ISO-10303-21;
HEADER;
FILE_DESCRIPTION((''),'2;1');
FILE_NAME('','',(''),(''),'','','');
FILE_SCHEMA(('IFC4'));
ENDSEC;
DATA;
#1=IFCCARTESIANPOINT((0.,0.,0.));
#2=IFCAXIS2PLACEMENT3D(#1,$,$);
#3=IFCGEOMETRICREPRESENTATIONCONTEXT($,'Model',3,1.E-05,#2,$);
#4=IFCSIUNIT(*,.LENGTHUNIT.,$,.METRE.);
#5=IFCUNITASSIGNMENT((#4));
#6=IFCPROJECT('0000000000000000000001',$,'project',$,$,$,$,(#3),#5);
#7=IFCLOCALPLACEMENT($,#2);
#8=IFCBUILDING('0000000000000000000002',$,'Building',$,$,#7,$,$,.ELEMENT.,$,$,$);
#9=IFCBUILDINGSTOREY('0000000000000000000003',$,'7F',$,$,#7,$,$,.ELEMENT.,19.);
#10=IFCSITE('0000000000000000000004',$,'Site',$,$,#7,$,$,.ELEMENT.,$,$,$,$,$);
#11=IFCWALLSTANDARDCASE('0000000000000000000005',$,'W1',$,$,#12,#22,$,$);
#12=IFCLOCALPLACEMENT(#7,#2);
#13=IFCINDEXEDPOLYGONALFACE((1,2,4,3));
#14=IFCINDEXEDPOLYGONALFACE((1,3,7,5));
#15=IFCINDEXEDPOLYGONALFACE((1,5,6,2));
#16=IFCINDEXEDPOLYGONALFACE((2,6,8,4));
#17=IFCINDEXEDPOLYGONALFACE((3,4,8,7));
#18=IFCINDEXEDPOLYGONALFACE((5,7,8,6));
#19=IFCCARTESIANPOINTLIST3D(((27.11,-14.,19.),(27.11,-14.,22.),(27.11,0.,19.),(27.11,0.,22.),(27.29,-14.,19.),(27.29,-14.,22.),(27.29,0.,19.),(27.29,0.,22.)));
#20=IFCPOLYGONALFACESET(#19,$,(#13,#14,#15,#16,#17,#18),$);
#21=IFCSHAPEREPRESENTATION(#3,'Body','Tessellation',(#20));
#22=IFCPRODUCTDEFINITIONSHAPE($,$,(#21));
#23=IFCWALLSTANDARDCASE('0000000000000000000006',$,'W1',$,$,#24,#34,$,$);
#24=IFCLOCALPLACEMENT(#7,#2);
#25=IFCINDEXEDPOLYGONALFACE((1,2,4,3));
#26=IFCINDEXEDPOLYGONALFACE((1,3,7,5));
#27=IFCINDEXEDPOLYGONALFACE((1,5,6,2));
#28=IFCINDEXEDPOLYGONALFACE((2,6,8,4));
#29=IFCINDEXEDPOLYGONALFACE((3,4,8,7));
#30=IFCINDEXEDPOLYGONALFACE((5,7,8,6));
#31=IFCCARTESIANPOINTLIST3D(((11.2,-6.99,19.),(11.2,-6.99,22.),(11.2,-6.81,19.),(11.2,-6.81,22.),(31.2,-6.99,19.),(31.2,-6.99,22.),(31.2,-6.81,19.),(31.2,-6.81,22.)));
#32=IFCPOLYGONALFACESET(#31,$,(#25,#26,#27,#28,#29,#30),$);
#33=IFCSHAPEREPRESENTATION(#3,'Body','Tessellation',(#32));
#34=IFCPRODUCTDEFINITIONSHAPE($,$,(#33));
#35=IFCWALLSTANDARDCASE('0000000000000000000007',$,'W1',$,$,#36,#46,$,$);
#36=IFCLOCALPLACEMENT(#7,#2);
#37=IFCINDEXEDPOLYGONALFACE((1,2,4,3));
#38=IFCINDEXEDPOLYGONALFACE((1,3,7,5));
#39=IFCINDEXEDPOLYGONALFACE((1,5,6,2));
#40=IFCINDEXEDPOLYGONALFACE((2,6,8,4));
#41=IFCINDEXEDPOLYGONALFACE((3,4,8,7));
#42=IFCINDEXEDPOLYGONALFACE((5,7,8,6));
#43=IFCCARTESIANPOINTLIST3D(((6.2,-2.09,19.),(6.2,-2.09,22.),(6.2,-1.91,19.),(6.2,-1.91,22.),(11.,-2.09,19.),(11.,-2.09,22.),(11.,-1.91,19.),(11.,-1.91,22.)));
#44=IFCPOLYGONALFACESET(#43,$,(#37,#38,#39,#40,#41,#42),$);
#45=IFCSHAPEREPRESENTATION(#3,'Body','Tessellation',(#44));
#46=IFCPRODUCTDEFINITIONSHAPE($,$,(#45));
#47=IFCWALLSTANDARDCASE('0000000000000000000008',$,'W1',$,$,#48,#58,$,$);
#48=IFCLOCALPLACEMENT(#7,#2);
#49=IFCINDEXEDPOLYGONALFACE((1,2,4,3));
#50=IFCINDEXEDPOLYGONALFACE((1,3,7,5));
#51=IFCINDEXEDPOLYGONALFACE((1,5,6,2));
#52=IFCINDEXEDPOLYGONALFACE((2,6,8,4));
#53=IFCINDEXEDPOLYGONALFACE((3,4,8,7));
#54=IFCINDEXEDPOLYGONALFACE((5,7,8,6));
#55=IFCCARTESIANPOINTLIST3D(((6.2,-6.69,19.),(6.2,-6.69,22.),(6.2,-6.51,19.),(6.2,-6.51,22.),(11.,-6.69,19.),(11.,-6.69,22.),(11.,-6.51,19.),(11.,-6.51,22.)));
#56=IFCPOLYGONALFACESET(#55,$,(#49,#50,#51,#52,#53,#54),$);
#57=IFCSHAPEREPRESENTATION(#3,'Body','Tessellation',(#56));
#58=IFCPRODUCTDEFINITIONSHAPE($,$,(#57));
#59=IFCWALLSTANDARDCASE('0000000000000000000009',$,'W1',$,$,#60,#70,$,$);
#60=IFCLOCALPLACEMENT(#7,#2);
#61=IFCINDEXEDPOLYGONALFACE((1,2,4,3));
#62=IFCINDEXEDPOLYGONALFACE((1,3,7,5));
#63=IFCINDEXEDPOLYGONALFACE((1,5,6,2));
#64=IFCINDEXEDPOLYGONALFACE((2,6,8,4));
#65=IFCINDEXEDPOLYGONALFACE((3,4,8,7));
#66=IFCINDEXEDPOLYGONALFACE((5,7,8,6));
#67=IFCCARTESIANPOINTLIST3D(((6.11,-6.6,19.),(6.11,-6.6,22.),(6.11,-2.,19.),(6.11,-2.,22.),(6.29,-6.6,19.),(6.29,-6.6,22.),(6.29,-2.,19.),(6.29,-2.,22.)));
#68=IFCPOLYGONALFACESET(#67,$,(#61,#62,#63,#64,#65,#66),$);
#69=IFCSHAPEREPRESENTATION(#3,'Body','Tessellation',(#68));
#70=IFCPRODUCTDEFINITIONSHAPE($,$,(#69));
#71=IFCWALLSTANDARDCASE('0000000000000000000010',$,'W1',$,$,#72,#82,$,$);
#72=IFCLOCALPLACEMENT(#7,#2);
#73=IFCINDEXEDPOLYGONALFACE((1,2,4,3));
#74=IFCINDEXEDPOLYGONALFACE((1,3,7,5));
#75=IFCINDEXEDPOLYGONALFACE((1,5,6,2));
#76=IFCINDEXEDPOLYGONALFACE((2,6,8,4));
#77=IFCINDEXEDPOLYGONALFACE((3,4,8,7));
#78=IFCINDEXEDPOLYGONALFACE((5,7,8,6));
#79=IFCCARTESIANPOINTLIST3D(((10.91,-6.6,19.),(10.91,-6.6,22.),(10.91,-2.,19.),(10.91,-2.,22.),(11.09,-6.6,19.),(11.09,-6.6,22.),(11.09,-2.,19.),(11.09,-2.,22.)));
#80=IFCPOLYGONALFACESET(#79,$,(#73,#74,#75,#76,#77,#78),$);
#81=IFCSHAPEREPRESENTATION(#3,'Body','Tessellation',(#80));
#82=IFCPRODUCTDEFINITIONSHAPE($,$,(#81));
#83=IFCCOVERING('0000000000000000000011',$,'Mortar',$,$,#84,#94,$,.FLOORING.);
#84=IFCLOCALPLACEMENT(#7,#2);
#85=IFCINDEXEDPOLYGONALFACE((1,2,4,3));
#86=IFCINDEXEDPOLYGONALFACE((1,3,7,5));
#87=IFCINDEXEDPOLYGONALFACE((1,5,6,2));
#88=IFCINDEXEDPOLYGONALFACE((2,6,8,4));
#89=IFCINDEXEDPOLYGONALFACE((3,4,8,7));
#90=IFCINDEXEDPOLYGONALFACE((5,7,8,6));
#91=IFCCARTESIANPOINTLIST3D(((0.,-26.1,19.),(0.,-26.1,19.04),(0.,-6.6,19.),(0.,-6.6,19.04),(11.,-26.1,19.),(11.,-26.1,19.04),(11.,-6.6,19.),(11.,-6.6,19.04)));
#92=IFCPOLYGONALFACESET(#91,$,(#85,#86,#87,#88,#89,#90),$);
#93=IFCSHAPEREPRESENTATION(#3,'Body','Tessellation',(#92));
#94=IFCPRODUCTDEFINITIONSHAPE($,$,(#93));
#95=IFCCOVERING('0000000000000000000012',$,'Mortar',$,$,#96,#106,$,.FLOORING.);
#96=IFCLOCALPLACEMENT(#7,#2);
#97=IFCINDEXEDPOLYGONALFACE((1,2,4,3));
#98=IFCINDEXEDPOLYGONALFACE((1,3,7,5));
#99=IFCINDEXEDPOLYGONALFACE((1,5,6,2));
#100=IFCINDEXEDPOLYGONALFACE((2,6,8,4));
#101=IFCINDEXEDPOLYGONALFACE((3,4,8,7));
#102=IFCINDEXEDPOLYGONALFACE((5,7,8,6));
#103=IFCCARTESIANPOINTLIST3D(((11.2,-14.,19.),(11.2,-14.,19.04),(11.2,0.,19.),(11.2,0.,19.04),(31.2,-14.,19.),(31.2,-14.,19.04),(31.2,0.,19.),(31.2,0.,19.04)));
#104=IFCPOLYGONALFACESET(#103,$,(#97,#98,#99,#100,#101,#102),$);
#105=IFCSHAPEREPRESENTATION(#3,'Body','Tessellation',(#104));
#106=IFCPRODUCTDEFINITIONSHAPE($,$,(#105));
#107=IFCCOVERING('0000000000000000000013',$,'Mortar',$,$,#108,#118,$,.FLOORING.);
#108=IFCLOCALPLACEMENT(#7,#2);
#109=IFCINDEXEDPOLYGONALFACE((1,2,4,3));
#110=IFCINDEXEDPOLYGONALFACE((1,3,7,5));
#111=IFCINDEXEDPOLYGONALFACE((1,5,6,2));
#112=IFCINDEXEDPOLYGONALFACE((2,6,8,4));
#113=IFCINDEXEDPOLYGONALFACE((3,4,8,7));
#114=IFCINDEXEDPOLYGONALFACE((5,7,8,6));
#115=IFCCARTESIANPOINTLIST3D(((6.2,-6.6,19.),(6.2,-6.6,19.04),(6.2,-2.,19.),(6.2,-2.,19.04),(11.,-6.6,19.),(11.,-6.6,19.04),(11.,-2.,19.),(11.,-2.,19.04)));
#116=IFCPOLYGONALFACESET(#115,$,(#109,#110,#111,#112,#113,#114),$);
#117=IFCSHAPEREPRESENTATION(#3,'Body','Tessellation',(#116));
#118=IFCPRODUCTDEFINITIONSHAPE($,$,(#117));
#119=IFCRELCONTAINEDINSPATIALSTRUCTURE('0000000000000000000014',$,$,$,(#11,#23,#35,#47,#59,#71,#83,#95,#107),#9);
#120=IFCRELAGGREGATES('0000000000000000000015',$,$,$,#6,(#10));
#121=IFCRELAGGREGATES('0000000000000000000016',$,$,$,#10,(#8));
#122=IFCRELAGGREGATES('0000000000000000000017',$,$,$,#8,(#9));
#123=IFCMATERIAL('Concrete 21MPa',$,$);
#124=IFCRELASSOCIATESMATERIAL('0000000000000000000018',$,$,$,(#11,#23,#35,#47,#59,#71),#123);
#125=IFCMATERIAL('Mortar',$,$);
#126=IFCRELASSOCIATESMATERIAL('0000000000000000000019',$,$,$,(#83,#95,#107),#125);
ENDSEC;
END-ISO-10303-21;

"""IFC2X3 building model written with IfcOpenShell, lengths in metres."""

from ifc_helpers import new_model, si_unit, frame, origin, origin_2d, place, context, project, spatial, rectangle, extrude, material, element, save


model = new_model("IFC2X3")

# Units and contexts
model_context = context("Model", 3, precision=1e-05, world=origin())
ifc_project = project(units=[si_unit("LENGTHUNIT", "METRE")], contexts=[model_context])

# Site, building, storey
placement = place(None, origin())
site = spatial("IfcSite", under=ifc_project, at=placement, Name="Site", CompositionType="ELEMENT")
building = spatial("IfcBuilding", under=site, at=placement, Name="Building", CompositionType="ELEMENT")
storey = spatial("IfcBuildingStorey", under=building, at=placement, Name="7F", CompositionType="ELEMENT", Elevation=19.0)

# Shared definitions
ifc_material_1 = material(Name="Concrete 21MPa")

# Walls
for number, where, name in (
    (1, (27.2, -7.0, 19.0), "W1"),
):
    element("IfcWallStandardCase", number, at=place(None, frame(where)), inside=storey, material=ifc_material_1, Name=name, context=model_context, shape_type="SweptSolid", body=[
        extrude(rectangle(XDim=0.18, YDim=14.0, at=origin_2d()), origin(), (0.0, 0.0, 1.0), 3.0),
    ])
wall_1_placement = place(None, frame((21.2, -6.9, 19.0)))
element("IfcWallStandardCase", 2, at=wall_1_placement, inside=storey, material=ifc_material_1, Name="W1", context=model_context, shape_type="SweptSolid", body=[
    extrude(rectangle(XDim=20.0, YDim=0.18, at=origin_2d()), origin(), (0.0, 0.0, 1.0), 3.0),
])
for number, where, name in (
    (3, (8.6, -2.0, 19.0), "W1"),
    (4, (8.6, -6.6, 19.0), "W1"),
):
    element("IfcWallStandardCase", number, at=place(None, frame(where)), inside=storey, material=ifc_material_1, Name=name, context=model_context, shape_type="SweptSolid", body=[
        extrude(rectangle(XDim=4.8, YDim=0.18, at=origin_2d()), origin(), (0.0, 0.0, 1.0), 3.0),
    ])
for number, where, name in (
    (5, (6.2, -4.3, 19.0), "W1"),
    (6, (11.0, -4.3, 19.0), "W1"),
):
    element("IfcWallStandardCase", number, at=place(None, frame(where)), inside=storey, material=ifc_material_1, Name=name, context=model_context, shape_type="SweptSolid", body=[
        extrude(rectangle(XDim=0.18, YDim=4.6, at=origin_2d()), origin(), (0.0, 0.0, 1.0), 3.0),
    ])

# Coverings
ifc_material_2 = material(Name="Mortar")
covering_1_placement = place(None, frame((5.5, -16.35, 19.0)))
element("IfcCovering", 7, at=covering_1_placement, inside=storey, material=ifc_material_2, Name="Mortar", PredefinedType="FLOORING", context=model_context, shape_type="SweptSolid", body=[
    extrude(rectangle(XDim=11.0, YDim=19.5, at=origin_2d()), origin(), (0.0, 0.0, 1.0), 0.04),
])
covering_2_placement = place(None, frame((21.2, -7.0, 19.0)))
element("IfcCovering", 8, at=covering_2_placement, inside=storey, material=ifc_material_2, Name="Mortar", PredefinedType="FLOORING", context=model_context, shape_type="SweptSolid", body=[
    extrude(rectangle(XDim=20.0, YDim=14.0, at=origin_2d()), origin(), (0.0, 0.0, 1.0), 0.04),
])
covering_3_placement = place(None, frame((8.6, -4.3, 19.0)))
element("IfcCovering", 9, at=covering_3_placement, inside=storey, material=ifc_material_2, Name="Mortar", PredefinedType="FLOORING", context=model_context, shape_type="SweptSolid", body=[
    extrude(rectangle(XDim=4.8, YDim=4.6, at=origin_2d()), origin(), (0.0, 0.0, 1.0), 0.04),
])

save(model, "model.ifc")
